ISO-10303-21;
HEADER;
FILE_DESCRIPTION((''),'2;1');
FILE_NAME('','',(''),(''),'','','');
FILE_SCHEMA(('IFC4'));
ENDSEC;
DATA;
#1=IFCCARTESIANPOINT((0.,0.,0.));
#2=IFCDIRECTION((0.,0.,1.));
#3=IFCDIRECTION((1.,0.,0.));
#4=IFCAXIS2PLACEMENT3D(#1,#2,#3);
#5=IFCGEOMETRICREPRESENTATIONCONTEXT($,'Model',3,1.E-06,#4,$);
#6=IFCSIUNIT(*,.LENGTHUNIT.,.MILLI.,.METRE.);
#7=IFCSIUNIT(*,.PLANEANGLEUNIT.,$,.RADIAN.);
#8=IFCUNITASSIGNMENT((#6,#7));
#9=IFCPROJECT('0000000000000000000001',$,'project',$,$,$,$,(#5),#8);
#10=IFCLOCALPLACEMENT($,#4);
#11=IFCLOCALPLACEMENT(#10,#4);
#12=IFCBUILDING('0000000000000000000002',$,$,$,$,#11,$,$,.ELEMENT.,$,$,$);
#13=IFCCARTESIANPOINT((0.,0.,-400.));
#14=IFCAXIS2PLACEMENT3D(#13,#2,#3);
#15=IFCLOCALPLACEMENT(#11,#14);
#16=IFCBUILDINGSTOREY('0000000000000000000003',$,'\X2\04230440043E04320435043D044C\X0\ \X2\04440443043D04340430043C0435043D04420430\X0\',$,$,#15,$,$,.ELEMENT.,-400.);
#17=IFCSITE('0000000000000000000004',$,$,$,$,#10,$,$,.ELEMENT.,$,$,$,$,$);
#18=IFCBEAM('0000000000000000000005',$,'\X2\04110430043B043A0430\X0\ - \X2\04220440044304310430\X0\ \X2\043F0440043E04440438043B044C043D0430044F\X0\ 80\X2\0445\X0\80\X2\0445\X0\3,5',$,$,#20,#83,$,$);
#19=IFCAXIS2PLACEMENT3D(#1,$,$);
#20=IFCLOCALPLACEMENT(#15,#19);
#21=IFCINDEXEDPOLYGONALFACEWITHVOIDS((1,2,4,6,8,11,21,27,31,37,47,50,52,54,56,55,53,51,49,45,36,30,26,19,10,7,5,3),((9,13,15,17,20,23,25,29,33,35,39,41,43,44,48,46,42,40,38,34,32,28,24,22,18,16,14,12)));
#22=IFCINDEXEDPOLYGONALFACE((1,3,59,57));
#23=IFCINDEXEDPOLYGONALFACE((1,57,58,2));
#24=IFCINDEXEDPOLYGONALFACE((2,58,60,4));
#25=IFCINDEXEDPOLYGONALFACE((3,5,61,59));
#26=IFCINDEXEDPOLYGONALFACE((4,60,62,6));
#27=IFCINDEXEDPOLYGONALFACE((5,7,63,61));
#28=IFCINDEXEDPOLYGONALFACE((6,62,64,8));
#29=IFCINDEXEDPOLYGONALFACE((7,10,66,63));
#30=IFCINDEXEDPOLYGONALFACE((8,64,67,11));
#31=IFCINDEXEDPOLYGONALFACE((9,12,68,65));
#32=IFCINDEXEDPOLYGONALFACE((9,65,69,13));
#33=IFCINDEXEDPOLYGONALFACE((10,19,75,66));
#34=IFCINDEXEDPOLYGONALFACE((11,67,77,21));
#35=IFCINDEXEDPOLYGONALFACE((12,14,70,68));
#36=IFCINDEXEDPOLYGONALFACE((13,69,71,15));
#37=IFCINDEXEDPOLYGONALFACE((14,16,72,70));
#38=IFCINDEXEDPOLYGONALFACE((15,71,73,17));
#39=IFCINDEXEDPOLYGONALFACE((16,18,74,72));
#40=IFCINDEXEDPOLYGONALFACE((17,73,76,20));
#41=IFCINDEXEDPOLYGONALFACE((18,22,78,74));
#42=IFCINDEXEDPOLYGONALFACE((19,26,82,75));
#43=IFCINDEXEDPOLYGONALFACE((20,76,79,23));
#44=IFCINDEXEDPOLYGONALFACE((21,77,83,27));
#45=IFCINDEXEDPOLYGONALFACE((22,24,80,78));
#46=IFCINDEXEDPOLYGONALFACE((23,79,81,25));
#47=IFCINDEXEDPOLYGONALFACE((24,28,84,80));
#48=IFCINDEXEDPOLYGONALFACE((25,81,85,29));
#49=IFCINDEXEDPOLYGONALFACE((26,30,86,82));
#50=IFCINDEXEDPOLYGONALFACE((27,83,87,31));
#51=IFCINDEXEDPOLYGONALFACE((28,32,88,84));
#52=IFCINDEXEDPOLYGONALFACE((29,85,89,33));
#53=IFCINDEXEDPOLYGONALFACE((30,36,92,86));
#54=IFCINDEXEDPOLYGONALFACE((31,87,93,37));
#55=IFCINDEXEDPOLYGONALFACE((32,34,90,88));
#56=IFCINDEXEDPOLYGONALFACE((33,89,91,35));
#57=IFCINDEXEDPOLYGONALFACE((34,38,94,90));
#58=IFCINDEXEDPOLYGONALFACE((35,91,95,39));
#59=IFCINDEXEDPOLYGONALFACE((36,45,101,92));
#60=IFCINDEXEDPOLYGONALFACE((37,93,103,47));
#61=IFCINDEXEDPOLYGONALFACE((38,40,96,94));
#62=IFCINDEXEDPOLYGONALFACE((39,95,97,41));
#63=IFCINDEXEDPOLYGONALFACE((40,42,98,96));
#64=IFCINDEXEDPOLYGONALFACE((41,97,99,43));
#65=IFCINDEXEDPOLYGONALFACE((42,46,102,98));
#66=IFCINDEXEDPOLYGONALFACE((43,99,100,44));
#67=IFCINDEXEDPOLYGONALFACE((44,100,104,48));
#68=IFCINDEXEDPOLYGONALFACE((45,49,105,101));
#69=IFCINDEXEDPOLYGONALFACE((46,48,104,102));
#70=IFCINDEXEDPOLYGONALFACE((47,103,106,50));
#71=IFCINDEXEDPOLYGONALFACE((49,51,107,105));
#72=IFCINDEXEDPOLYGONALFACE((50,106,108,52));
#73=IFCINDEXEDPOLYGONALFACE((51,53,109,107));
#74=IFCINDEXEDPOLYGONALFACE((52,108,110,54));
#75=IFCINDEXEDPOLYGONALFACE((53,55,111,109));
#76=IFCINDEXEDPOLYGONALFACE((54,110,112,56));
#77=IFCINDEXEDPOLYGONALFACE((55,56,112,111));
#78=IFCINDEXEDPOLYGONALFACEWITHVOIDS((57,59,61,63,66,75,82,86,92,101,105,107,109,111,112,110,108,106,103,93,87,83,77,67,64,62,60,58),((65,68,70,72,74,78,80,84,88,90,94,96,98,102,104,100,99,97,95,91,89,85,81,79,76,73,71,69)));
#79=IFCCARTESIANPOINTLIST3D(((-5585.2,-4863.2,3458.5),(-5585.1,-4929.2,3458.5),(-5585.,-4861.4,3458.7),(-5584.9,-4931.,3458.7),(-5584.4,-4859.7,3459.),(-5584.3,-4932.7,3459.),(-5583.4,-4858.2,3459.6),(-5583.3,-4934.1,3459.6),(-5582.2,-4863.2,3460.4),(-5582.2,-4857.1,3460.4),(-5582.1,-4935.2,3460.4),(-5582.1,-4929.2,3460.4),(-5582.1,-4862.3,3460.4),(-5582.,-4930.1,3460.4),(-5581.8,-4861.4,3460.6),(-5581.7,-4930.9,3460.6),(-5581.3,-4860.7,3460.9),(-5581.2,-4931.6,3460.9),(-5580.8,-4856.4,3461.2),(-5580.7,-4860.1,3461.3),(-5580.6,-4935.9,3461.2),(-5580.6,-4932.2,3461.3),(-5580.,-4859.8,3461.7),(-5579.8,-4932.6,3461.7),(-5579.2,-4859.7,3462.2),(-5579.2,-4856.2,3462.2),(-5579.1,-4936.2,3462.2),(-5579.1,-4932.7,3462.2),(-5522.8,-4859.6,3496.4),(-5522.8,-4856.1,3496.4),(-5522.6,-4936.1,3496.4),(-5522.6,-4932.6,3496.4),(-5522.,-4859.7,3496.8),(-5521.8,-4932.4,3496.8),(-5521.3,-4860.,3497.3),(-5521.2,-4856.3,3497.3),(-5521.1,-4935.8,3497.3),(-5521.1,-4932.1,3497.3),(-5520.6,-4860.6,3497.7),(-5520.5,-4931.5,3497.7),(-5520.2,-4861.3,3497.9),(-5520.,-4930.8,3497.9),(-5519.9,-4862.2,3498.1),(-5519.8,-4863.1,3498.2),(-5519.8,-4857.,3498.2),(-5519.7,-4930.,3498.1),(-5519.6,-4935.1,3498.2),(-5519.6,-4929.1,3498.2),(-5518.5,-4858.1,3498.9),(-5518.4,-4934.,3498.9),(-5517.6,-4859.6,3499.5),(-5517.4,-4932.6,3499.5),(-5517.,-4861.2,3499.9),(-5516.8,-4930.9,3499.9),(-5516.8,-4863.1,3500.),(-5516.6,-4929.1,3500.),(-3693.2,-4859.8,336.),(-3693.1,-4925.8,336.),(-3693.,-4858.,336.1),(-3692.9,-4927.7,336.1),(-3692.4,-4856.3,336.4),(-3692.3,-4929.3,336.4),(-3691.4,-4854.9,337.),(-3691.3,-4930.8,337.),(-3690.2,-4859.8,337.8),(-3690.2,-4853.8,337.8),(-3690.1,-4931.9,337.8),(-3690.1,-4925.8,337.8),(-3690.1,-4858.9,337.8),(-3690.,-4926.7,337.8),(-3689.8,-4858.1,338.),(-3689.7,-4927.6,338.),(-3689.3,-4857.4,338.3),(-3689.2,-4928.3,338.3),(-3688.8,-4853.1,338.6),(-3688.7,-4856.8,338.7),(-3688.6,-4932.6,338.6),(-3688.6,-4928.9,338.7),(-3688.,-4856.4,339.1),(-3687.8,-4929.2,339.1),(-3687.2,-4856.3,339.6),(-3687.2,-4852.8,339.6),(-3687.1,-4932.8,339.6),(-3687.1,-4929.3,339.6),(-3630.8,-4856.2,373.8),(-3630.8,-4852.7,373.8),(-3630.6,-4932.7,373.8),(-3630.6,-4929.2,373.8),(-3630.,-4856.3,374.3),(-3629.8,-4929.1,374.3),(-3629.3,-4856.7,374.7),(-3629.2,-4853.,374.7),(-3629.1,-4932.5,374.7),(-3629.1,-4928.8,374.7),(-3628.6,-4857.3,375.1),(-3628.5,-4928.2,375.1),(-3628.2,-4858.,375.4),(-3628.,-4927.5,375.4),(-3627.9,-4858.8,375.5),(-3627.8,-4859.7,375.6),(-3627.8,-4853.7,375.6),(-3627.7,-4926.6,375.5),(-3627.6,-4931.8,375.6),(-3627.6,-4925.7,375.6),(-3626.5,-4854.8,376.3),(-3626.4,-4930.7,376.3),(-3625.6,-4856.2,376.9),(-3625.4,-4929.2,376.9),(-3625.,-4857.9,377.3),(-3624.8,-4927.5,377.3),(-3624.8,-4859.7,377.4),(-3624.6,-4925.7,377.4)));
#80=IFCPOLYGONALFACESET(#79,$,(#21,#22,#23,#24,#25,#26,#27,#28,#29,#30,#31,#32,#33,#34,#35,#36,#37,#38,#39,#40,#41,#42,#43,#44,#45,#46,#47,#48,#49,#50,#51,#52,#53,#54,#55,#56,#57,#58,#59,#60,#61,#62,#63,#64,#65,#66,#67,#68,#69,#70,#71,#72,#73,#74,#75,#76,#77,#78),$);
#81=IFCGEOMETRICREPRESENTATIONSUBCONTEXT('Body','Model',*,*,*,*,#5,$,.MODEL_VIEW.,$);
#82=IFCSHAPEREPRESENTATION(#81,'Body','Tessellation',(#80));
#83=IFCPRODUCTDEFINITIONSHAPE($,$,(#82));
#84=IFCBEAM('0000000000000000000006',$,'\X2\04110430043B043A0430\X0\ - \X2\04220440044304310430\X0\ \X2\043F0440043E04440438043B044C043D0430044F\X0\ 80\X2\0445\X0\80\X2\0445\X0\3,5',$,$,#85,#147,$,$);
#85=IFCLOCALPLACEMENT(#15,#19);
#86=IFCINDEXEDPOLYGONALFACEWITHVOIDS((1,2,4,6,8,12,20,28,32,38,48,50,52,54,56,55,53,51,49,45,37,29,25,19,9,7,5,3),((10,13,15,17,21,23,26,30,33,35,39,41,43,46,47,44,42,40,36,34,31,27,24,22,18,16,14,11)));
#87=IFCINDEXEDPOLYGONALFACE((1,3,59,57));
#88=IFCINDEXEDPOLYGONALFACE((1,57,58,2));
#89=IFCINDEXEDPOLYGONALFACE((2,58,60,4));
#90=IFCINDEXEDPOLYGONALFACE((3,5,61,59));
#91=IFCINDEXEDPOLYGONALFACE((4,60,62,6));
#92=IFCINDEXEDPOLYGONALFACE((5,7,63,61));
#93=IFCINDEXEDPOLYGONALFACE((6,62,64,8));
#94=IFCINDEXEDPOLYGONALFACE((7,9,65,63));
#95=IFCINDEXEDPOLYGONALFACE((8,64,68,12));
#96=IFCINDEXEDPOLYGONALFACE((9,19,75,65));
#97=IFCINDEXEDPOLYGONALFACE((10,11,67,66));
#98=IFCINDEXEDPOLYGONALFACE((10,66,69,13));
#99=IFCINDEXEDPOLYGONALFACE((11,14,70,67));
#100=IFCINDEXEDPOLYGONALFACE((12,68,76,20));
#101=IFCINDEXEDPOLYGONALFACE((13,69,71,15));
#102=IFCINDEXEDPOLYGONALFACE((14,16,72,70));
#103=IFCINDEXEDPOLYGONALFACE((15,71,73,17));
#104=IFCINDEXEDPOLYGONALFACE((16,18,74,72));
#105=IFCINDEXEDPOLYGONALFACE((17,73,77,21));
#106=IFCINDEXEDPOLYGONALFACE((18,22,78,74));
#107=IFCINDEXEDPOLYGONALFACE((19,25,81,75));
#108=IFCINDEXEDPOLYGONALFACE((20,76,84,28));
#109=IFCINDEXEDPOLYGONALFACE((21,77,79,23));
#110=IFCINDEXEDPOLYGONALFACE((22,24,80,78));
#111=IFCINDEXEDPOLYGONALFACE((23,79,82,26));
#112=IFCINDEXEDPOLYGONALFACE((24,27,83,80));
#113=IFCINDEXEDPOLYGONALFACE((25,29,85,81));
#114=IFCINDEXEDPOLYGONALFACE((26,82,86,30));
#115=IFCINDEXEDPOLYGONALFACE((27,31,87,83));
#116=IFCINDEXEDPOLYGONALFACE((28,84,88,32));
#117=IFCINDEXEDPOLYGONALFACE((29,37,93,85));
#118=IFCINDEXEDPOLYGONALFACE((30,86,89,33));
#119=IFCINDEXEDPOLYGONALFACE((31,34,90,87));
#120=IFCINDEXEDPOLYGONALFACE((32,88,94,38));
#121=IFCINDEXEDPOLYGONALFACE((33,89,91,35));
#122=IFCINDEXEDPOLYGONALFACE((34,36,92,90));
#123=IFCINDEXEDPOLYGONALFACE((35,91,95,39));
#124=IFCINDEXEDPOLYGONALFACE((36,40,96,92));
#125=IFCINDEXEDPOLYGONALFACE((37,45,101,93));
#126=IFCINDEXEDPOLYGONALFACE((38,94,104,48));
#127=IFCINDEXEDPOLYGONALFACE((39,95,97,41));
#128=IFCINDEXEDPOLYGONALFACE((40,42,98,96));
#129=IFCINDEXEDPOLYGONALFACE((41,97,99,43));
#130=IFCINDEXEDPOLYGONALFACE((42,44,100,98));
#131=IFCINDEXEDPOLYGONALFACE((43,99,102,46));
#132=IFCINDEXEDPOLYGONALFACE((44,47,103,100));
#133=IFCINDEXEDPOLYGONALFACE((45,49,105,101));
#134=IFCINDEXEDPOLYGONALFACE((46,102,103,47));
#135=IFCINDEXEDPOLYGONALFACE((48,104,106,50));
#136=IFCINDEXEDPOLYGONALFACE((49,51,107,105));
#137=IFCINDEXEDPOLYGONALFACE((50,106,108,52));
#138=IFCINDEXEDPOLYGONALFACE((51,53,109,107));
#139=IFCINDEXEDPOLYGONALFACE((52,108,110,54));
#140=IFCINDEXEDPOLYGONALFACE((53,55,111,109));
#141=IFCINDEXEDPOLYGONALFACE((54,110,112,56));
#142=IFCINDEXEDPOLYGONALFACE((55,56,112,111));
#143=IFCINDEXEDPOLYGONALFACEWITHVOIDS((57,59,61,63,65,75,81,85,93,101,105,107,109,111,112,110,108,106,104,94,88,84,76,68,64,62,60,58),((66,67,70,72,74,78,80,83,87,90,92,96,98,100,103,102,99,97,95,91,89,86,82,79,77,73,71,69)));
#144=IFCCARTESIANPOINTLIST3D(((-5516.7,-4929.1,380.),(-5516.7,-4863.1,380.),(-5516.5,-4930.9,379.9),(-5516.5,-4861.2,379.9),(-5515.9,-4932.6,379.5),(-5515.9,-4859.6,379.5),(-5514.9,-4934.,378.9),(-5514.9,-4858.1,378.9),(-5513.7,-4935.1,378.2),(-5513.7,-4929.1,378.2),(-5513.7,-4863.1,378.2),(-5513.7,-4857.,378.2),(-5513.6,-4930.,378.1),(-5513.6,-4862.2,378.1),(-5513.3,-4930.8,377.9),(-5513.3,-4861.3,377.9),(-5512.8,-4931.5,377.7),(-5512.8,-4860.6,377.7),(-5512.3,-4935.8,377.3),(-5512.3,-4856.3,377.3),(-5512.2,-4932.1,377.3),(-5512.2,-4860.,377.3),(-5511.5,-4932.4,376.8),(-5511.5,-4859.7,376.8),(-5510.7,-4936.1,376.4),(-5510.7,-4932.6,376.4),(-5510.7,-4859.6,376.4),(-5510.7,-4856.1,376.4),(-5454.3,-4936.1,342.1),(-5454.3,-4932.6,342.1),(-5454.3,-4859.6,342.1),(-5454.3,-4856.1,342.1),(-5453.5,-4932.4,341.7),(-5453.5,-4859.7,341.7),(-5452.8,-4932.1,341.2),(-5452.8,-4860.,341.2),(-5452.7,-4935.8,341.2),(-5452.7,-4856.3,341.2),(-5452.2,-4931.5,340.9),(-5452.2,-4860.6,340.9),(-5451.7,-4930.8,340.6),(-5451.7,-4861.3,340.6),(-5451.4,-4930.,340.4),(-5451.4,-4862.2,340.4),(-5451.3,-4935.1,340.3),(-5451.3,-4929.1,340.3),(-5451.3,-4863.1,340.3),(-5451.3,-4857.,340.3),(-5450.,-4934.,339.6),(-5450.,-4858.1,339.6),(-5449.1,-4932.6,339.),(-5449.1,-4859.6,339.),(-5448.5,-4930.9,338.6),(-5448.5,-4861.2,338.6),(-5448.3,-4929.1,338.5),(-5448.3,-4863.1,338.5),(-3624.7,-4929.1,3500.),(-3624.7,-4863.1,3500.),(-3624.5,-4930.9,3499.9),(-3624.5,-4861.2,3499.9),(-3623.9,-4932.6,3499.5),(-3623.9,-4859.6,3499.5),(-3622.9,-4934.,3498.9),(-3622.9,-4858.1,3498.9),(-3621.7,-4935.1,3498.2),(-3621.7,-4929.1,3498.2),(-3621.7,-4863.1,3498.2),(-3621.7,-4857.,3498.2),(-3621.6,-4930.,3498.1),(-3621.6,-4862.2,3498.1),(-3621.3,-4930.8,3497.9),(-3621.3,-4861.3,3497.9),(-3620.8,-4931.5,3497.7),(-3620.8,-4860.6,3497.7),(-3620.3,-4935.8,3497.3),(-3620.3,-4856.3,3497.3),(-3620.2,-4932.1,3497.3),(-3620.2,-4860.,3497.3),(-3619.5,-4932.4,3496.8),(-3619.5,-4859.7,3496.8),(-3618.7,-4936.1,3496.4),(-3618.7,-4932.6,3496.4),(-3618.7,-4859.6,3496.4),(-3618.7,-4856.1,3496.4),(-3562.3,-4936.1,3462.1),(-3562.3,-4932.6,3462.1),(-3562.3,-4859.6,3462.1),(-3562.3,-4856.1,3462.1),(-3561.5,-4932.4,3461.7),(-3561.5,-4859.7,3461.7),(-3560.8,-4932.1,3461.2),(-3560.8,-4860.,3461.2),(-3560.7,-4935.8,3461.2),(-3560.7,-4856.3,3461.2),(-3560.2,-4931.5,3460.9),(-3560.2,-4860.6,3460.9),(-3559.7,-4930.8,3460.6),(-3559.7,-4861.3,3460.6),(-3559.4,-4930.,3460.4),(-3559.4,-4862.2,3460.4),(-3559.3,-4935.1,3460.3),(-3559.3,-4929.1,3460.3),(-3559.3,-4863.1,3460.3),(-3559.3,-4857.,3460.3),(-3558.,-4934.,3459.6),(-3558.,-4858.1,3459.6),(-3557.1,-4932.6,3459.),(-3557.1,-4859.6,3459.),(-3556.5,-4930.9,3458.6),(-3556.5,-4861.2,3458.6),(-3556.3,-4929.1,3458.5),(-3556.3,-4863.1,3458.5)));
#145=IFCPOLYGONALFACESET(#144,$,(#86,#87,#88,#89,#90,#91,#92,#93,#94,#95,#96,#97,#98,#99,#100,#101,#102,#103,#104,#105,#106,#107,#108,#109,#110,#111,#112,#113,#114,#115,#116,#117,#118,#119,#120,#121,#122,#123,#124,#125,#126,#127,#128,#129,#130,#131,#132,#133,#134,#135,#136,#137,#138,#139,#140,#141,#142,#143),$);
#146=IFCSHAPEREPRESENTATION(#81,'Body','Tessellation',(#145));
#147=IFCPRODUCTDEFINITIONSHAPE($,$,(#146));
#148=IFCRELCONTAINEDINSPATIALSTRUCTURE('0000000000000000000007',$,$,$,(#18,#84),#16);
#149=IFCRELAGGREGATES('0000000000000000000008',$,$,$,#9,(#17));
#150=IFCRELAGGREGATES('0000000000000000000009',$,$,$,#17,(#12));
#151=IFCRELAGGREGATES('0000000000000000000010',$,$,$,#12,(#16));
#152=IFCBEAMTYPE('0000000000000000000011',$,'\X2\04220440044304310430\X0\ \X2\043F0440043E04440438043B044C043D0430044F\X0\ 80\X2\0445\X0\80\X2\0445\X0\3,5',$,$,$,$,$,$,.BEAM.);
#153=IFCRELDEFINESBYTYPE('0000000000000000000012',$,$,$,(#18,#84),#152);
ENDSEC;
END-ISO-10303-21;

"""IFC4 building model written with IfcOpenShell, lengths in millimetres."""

from ifc_helpers import new_model, si_unit, frame, origin_with_axes, place, context, subcontext, project, spatial, line, arc, indexed_curve, outline, extrude, source, transform, mapped, type_object, element, save


model = new_model("IFC4")

# Units and contexts
model_context = context("Model", 3, precision=1e-06, world=origin_with_axes())
body_context = subcontext(model_context, "Body", "Model", "MODEL_VIEW")
ifc_project = project(units=[si_unit("LENGTHUNIT", "METRE", prefix="MILLI"), si_unit("PLANEANGLEUNIT", "RADIAN")], contexts=[model_context])

# Site, building, storey
site_placement = place(None, origin_with_axes())
site = spatial("IfcSite", under=ifc_project, at=site_placement, CompositionType="ELEMENT")
building_placement = place(site_placement, origin_with_axes())
building = spatial("IfcBuilding", under=site, at=building_placement, CompositionType="ELEMENT")
storey_placement = place(building_placement, frame((0.0, 0.0, -400.0), z_axis=(0.0, 0.0, 1.0), x_axis=(1.0, 0.0, 0.0)))
storey = spatial("IfcBuildingStorey", under=building, at=storey_placement, Name="Уровень фундамента", CompositionType="ELEMENT", Elevation=-400.0)

# Beams
beam_type_1 = type_object("IfcBeamType", Name="Труба профильная 80х80х3,5", PredefinedType="BEAM")
shared_shape_1 = source(origin_with_axes(), body_context, "Body", "SweptSolid", [
    extrude(outline(indexed_curve([(-40.0, -73.0), (-37.9, -77.9), (-33.0, -80.0), (33.0, -80.0), (37.9, -77.9), (40.0, -73.0), (40.0, -7.0), (37.9, -2.1), (33.0, 0.0), (-33.0, 0.0), (-37.9, -2.1), (-40.0, -7.0)], segments=[arc(1, 2, 3), line(3, 4), arc(4, 5, 6), line(6, 7), arc(7, 8, 9), line(9, 10), arc(10, 11, 12), line(12, 1)]), holes=[indexed_curve([(-36.5, -7.0), (-35.5, -4.5), (-33.0, -3.5), (33.0, -3.5), (35.5, -4.5), (36.5, -7.0), (36.5, -73.0), (35.5, -75.5), (33.0, -76.5), (-33.0, -76.5), (-35.5, -75.5), (-36.5, -73.0)], segments=[arc(1, 2, 3), line(3, 4), arc(4, 5, 6), line(6, 7), arc(7, 8, 9), line(9, 10), arc(10, 11, 12), line(12, 1)])]), origin_with_axes(), (0.0, 0.0, -1.0), 3651.1),
])
beam_1_placement = place(storey_placement, frame((-5516.7, -4896.1, 3500.0), z_axis=(-0.518206, -0.000915, 0.855255), x_axis=(0.001765, -0.999998, 0.0)))
element("IfcBeam", 1, at=beam_1_placement, inside=storey, type_object=beam_type_1, Name="Балка - Труба профильная 80х80х3,5", context=body_context, shape_type="MappedRepresentation", body=[
    mapped(shared_shape_1, transform((0.0, 0.0, 0.0), x_axis=(1.0, 0.0, 0.0), y_axis=(0.0, 1.0, 0.0), z_axis=(0.0, 0.0, 1.0), scale=1.0)),
])
shared_shape_2 = source(origin_with_axes(), body_context, "Body", "SweptSolid", [
    extrude(outline(indexed_curve([(-40.0, -73.0), (-37.9, -77.9), (-33.0, -80.0), (33.0, -80.0), (37.9, -77.9), (40.0, -73.0), (40.0, -7.0), (37.9, -2.1), (33.0, 0.0), (-33.0, 0.0), (-37.9, -2.1), (-40.0, -7.0)], segments=[arc(1, 2, 3), line(3, 4), arc(4, 5, 6), line(6, 7), arc(7, 8, 9), line(9, 10), arc(10, 11, 12), line(12, 1)]), holes=[indexed_curve([(-36.5, -7.0), (-35.5, -4.5), (-33.0, -3.5), (33.0, -3.5), (35.5, -4.5), (36.5, -7.0), (36.5, -73.0), (35.5, -75.5), (33.0, -76.5), (-33.0, -76.5), (-35.5, -75.5), (-36.5, -73.0)], segments=[arc(1, 2, 3), line(3, 4), arc(4, 5, 6), line(6, 7), arc(7, 8, 9), line(9, 10), arc(10, 11, 12), line(12, 1)])]), origin_with_axes(), (0.0, 0.0, -1.0), 3648.8),
])
beam_2_placement = place(storey_placement, frame((-3624.7, -4896.1, 3500.0), z_axis=(0.51852, 0.0, 0.855065), x_axis=(0.0, 1.0, 0.0)))
element("IfcBeam", 2, at=beam_2_placement, inside=storey, type_object=beam_type_1, Name="Балка - Труба профильная 80х80х3,5", context=body_context, shape_type="MappedRepresentation", body=[
    mapped(shared_shape_2, transform((0.0, 0.0, 0.0), x_axis=(1.0, 0.0, 0.0), y_axis=(0.0, 1.0, 0.0), z_axis=(0.0, 0.0, 1.0), scale=1.0)),
])

save(model, "model.ifc")
